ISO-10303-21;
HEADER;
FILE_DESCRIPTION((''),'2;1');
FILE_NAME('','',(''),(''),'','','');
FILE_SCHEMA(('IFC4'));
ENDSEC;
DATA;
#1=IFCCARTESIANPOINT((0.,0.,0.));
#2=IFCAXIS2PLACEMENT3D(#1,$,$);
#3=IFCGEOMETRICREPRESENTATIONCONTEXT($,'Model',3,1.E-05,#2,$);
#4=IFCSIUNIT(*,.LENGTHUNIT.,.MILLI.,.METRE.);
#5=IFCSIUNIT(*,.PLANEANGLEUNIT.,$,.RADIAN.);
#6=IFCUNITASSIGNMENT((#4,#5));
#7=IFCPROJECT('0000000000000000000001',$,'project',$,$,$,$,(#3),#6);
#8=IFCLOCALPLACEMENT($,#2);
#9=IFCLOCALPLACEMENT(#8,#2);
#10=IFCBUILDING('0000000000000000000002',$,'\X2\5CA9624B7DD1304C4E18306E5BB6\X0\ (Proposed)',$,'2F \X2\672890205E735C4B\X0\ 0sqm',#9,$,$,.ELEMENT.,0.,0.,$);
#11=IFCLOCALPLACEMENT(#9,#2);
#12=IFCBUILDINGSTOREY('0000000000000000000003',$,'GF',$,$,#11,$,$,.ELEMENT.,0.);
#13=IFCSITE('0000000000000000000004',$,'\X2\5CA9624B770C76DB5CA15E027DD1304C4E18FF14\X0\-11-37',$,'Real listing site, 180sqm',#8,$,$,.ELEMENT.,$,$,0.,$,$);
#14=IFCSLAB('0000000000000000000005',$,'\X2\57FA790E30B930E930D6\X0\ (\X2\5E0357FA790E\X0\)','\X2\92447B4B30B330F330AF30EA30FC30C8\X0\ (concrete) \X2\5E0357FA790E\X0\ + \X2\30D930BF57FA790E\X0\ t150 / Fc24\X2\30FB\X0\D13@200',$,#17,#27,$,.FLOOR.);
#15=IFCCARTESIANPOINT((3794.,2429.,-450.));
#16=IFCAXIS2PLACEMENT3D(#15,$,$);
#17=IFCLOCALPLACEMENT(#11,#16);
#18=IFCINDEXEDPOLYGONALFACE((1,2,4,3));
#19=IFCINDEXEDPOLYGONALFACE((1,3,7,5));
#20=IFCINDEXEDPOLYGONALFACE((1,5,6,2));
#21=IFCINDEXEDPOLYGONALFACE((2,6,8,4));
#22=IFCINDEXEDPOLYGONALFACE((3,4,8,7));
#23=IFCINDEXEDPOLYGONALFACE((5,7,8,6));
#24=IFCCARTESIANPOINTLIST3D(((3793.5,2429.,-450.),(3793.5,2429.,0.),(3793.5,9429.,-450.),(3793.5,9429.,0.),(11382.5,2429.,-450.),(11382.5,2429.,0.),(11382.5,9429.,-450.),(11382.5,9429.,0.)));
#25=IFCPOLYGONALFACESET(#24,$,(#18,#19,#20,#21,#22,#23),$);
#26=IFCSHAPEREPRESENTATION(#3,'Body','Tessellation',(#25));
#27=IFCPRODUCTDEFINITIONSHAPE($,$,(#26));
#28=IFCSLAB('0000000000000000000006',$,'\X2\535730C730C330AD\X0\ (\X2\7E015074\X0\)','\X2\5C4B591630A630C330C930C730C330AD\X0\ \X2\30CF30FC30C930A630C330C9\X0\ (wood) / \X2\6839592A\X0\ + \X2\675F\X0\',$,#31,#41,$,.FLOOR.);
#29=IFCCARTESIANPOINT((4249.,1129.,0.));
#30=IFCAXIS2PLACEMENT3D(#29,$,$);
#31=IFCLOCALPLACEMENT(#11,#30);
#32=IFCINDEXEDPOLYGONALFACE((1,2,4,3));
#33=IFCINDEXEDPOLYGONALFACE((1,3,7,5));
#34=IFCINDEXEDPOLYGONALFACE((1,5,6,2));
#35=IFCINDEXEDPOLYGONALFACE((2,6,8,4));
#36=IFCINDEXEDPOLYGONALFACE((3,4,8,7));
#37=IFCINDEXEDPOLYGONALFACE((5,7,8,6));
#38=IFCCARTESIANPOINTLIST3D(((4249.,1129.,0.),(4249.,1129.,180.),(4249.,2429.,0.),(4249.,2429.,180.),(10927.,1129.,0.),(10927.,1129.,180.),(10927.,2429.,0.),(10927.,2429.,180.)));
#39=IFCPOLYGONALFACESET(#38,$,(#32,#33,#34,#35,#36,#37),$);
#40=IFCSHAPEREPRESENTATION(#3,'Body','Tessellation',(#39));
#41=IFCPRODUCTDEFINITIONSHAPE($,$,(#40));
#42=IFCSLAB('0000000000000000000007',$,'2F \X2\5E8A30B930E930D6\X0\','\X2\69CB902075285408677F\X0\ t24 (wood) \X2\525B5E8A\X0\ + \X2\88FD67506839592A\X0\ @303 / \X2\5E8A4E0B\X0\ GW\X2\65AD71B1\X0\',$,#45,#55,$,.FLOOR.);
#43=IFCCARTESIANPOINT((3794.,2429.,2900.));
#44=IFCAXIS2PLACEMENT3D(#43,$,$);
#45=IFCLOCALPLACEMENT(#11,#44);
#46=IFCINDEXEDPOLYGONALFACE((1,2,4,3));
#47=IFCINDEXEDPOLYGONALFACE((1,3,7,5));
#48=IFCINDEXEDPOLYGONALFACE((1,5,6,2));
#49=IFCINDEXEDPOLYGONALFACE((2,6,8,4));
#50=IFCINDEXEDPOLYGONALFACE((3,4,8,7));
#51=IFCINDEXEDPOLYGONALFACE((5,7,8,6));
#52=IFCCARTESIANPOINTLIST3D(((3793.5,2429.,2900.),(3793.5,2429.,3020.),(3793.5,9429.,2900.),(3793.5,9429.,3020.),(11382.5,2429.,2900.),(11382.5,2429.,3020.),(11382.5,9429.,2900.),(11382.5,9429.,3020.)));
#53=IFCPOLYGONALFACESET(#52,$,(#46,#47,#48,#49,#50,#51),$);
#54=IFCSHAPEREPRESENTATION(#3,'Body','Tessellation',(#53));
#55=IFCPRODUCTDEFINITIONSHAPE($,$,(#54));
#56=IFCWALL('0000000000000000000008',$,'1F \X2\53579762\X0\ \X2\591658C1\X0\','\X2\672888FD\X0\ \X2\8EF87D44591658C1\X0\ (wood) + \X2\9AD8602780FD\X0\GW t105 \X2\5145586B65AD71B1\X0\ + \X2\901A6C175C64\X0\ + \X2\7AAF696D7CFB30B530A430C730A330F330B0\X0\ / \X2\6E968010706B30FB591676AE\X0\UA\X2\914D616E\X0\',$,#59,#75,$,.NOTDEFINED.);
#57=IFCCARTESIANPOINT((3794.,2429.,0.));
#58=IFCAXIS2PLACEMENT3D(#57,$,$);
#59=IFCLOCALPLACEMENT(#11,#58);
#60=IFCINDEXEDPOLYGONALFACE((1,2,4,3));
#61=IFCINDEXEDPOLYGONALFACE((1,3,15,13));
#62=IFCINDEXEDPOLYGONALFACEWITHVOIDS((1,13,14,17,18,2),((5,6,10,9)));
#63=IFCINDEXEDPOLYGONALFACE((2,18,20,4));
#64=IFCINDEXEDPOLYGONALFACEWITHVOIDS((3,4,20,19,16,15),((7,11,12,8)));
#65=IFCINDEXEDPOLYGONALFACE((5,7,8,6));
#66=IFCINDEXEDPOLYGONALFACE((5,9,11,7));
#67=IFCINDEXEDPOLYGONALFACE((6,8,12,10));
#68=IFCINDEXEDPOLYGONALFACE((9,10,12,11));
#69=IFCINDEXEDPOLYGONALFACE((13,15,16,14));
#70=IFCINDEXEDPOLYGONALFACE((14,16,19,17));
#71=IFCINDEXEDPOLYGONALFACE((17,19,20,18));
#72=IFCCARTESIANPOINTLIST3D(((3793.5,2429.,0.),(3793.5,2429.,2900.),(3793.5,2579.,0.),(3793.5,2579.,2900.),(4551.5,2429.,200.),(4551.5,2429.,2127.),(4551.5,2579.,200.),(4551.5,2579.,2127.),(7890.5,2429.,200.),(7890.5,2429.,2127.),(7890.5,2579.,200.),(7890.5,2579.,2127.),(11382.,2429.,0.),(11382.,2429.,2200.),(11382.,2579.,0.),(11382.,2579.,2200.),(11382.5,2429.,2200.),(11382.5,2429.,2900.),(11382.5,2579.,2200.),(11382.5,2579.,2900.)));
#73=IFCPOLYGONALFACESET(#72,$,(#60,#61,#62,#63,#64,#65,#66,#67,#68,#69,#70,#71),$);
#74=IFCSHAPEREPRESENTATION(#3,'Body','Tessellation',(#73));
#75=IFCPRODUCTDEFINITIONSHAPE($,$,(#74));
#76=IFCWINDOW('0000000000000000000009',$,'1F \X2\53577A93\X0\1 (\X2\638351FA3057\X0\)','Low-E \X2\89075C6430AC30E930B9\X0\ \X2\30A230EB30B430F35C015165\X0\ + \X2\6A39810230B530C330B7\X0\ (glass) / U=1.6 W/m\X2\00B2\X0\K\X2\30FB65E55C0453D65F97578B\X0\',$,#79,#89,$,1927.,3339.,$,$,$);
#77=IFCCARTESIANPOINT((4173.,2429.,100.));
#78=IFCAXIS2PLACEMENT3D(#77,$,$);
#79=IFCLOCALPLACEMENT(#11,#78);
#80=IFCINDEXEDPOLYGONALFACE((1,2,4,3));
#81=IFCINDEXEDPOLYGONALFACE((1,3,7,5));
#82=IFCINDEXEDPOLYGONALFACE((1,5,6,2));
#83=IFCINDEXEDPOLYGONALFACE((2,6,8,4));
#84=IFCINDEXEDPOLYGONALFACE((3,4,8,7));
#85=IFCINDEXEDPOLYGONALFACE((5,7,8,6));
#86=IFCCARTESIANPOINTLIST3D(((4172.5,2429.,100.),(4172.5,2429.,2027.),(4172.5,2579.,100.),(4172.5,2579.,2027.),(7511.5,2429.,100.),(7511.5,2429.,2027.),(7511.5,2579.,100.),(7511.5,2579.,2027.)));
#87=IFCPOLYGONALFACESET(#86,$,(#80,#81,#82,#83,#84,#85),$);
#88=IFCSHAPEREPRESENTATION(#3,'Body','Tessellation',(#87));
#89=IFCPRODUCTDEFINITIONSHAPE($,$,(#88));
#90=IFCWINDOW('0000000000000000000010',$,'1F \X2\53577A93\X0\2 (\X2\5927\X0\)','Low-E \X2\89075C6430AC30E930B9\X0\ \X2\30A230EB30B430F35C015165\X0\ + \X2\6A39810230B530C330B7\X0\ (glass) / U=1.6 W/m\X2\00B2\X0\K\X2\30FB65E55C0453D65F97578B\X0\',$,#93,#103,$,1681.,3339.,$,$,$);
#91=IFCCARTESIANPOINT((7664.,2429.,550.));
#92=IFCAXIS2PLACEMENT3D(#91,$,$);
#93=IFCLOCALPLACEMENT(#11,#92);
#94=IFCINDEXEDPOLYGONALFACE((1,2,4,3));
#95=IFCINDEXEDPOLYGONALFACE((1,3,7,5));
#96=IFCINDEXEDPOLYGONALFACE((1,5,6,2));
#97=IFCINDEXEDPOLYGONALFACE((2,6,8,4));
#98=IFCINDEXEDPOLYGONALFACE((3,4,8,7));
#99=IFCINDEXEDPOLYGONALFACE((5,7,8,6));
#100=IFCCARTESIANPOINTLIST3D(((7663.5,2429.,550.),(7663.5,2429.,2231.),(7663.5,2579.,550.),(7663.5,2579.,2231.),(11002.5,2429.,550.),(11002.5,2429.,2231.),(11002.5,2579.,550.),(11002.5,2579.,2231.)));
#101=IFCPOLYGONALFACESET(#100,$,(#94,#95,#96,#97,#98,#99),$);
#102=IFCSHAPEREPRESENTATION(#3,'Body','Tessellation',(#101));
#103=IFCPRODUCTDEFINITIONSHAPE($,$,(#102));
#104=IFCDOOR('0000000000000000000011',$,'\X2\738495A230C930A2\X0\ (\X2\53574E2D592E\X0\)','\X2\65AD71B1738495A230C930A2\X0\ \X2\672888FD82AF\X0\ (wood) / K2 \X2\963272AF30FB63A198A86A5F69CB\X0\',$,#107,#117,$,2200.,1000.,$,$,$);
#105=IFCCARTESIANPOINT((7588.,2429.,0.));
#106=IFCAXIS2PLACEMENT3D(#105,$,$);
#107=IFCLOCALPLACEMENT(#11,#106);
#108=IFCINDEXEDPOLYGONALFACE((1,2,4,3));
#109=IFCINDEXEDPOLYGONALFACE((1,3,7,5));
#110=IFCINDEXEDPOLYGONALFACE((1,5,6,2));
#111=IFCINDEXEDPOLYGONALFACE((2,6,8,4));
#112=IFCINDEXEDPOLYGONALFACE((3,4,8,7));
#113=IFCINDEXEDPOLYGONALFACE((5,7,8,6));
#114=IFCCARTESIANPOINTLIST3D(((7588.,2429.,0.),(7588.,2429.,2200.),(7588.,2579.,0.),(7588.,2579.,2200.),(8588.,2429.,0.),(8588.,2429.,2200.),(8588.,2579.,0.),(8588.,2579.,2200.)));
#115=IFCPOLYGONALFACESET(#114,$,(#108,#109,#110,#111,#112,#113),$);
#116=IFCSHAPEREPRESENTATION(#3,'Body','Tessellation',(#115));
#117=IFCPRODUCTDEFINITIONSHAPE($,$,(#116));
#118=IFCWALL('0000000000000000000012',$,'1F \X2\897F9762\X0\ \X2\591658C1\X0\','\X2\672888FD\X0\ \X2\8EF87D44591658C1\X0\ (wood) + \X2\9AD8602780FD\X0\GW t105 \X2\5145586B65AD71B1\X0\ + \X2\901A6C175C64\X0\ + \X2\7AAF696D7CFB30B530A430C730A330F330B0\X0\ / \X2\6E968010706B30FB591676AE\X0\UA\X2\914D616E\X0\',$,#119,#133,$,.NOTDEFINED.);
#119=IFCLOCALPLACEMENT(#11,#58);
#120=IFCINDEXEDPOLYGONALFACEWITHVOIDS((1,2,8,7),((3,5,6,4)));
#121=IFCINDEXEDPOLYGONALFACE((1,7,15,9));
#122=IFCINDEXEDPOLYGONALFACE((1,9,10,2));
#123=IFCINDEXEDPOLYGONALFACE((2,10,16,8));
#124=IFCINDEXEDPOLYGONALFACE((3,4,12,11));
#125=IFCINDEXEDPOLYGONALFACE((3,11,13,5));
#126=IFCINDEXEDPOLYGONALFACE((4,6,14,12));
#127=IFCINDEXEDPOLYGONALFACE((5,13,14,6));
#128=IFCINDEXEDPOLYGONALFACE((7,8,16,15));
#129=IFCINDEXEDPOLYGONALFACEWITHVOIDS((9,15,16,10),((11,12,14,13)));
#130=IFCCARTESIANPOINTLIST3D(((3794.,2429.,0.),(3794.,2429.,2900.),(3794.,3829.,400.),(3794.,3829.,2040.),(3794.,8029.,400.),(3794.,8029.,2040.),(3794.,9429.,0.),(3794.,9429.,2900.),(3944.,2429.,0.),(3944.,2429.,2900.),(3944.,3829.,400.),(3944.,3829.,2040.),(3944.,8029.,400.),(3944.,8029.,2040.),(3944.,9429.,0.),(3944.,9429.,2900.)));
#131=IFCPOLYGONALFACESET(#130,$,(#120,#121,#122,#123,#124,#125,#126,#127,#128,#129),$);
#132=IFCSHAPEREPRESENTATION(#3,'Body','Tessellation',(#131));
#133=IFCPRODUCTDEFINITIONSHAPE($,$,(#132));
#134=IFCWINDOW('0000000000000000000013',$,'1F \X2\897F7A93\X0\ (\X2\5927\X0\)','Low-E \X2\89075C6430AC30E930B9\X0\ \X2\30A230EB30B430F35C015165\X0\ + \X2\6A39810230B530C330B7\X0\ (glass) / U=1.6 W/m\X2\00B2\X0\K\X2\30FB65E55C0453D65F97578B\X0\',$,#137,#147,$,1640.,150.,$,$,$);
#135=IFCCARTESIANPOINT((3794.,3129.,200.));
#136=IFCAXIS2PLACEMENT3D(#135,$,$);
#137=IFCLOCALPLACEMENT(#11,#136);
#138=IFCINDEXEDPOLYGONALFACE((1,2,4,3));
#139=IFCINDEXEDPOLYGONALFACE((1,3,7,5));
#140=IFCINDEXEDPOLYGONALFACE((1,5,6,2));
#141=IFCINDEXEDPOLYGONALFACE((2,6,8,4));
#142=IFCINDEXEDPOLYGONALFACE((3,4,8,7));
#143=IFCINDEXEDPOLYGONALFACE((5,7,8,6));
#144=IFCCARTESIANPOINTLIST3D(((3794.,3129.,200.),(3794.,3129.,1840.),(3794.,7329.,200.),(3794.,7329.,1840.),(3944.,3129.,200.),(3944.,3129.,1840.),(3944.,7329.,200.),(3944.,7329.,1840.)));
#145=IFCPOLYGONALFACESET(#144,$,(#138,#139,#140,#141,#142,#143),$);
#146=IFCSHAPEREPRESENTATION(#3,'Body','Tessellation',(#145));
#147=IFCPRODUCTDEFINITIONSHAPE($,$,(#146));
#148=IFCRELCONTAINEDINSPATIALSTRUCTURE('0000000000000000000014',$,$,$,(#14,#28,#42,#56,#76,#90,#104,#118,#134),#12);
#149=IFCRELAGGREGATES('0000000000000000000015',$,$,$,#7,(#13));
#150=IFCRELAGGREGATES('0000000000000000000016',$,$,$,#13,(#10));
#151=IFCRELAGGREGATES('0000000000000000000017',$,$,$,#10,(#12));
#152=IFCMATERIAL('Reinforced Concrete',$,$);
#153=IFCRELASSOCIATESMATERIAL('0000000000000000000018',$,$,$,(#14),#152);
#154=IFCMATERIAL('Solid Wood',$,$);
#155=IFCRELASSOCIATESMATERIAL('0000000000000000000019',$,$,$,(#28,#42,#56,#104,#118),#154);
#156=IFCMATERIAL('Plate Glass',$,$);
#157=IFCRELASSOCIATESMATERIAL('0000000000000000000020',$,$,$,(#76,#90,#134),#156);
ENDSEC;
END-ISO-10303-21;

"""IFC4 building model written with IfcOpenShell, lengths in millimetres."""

from ifc_helpers import new_model, si_unit, frame, frame_2d, origin, place, context, project, spatial, rectangle, extrude, material, element, fill, save


model = new_model("IFC4")

# Units and contexts
model_context = context("Model", 3, precision=1e-05, world=origin())
ifc_project = project(units=[si_unit("LENGTHUNIT", "METRE", prefix="MILLI"), si_unit("PLANEANGLEUNIT", "RADIAN")], contexts=[model_context])

# Site, building, storey
site_placement = place(None, origin())
site = spatial("IfcSite", under=ifc_project, at=site_placement, Name="岩手県盛岡市緑が丘４-11-37", ObjectType="Real listing site, 180sqm", CompositionType="ELEMENT", RefElevation=0.0)
building_placement = place(site_placement, origin())
building = spatial("IfcBuilding", under=site, at=building_placement, Name="岩手緑が丘の家 (Proposed)", ObjectType="2F 木造平屋 0sqm", CompositionType="ELEMENT", ElevationOfRefHeight=0.0, ElevationOfTerrain=0.0)
storey_placement = place(building_placement, origin())
storey = spatial("IfcBuildingStorey", under=building, at=storey_placement, Name="GF", CompositionType="ELEMENT", Elevation=0.0)

# Slabs
ifc_material_1 = material(Name="Reinforced Concrete")
slab_1_placement = place(storey_placement, frame((3794.0, 2429.0, -450.0)))
element("IfcSlab", 1, at=slab_1_placement, inside=storey, material=ifc_material_1, Name="基礎スラブ (布基礎)", Description="鉄筋コンクリート (concrete) 布基礎 + ベタ基礎 t150 / Fc24・D13@200", PredefinedType="FLOOR", context=model_context, shape_type="SweptSolid", body=[
    extrude(rectangle(XDim=7589.0, YDim=7000.0, at=frame_2d((3794.0, 3500.0))), frame((3794.0, 2429.0, -450.0)), (0.0, 0.0, 1.0), 450.0),
])
ifc_material_2 = material(Name="Solid Wood")
slab_2_placement = place(storey_placement, frame((4249.0, 1129.0, 0.0)))
element("IfcSlab", 2, at=slab_2_placement, inside=storey, material=ifc_material_2, Name="南デッキ (縁側)", Description="屋外ウッドデッキ ハードウッド (wood) / 根太 + 束", PredefinedType="FLOOR", context=model_context, shape_type="SweptSolid", body=[
    extrude(rectangle(XDim=6678.0, YDim=1300.0, at=frame_2d((3339.0, 650.0))), frame((4249.0, 1129.0, 0.0)), (0.0, 0.0, 1.0), 180.0),
])
slab_3_placement = place(storey_placement, frame((3794.0, 2429.0, 2900.0)))
element("IfcSlab", 3, at=slab_3_placement, inside=storey, material=ifc_material_2, Name="2F 床スラブ", Description="構造用合板 t24 (wood) 剛床 + 製材根太 @303 / 床下 GW断熱", PredefinedType="FLOOR", context=model_context, shape_type="SweptSolid", body=[
    extrude(rectangle(XDim=7589.0, YDim=7000.0, at=frame_2d((3794.0, 3500.0))), frame((3794.0, 2429.0, 2900.0)), (0.0, 0.0, 1.0), 120.0),
])

# Wall, openings, windows, door
wall_1_placement = place(storey_placement, frame((3794.0, 2429.0, 0.0)))
wall_1 = element("IfcWall", 4, at=wall_1_placement, inside=storey, material=ifc_material_2, Name="1F 南面 外壁", Description="木製 軸組外壁 (wood) + 高性能GW t105 充填断熱 + 通気層 + 窯業系サイディング / 準耐火・外皮UA配慮", PredefinedType="NOTDEFINED", context=model_context, shape_type="SweptSolid", body=[
    extrude(rectangle(XDim=7589.0, YDim=150.0, at=frame_2d((3794.0, 75.0))), frame((3794.0, 2429.0, 0.0)), (0.0, 0.0, 1.0), 2900.0),
])
opening_1_placement = place(storey_placement, frame((4173.0, 2429.0, 100.0)))
opening_1 = element("IfcOpeningElement", 5, at=opening_1_placement, cuts=wall_1, PredefinedType="NOTDEFINED", context=model_context, shape_type="SweptSolid", body=[
    extrude(rectangle(XDim=3339.0, YDim=150.0, at=frame_2d((1669.0, 75.0))), frame((4173.0, 2429.0, 100.0)), (0.0, 0.0, 1.0), 1927.0),
])
opening_2_placement = place(storey_placement, frame((7664.0, 2429.0, 550.0)))
opening_2 = element("IfcOpeningElement", 6, at=opening_2_placement, cuts=wall_1, PredefinedType="NOTDEFINED", context=model_context, shape_type="SweptSolid", body=[
    extrude(rectangle(XDim=3339.0, YDim=150.0, at=frame_2d((1669.0, 75.0))), frame((7664.0, 2429.0, 550.0)), (0.0, 0.0, 1.0), 1681.0),
])
opening_3_placement = place(storey_placement, frame((7588.0, 2429.0, 0.0)))
opening_3 = element("IfcOpeningElement", 7, at=opening_3_placement, cuts=wall_1, PredefinedType="NOTDEFINED", context=model_context, shape_type="SweptSolid", body=[
    extrude(rectangle(XDim=1000.0, YDim=150.0, at=frame_2d((500.0, 75.0))), frame((7588.0, 2429.0, 0.0)), (0.0, 0.0, 1.0), 2200.0),
])
ifc_material_3 = material(Name="Plate Glass")
window_1_placement = place(storey_placement, frame((4173.0, 2429.0, 100.0)))
window_1 = element("IfcWindow", 8, at=window_1_placement, inside=storey, material=ifc_material_3, Name="1F 南窓1 (掃出し)", Description="Low-E 複層ガラス アルゴン封入 + 樹脂サッシ (glass) / U=1.6 W/m²K・日射取得型", OverallHeight=1927.0, OverallWidth=3339.0, context=model_context, shape_type="SweptSolid", body=[
    extrude(rectangle(XDim=3339.0, YDim=150.0, at=frame_2d((1669.0, 75.0))), frame((4173.0, 2429.0, 100.0)), (0.0, 0.0, 1.0), 1927.0),
])
fill(opening_1, window_1)
window_2_placement = place(storey_placement, frame((7664.0, 2429.0, 550.0)))
window_2 = element("IfcWindow", 9, at=window_2_placement, inside=storey, material=ifc_material_3, Name="1F 南窓2 (大)", Description="Low-E 複層ガラス アルゴン封入 + 樹脂サッシ (glass) / U=1.6 W/m²K・日射取得型", OverallHeight=1681.0, OverallWidth=3339.0, context=model_context, shape_type="SweptSolid", body=[
    extrude(rectangle(XDim=3339.0, YDim=150.0, at=frame_2d((1669.0, 75.0))), frame((7664.0, 2429.0, 550.0)), (0.0, 0.0, 1.0), 1681.0),
])
fill(opening_2, window_2)
door_placement = place(storey_placement, frame((7588.0, 2429.0, 0.0)))
door = element("IfcDoor", 10, at=door_placement, inside=storey, material=ifc_material_2, Name="玄関ドア (南中央)", Description="断熱玄関ドア 木製芯 (wood) / K2 防犯・採風機構", OverallHeight=2200.0, OverallWidth=1000.0, context=model_context, shape_type="SweptSolid", body=[
    extrude(rectangle(XDim=1000.0, YDim=150.0, at=frame_2d((500.0, 75.0))), frame((7588.0, 2429.0, 0.0)), (0.0, 0.0, 1.0), 2200.0),
])
fill(opening_3, door)

# Wall, opening, window
wall_2_placement = place(storey_placement, frame((3794.0, 2429.0, 0.0)))
wall_2 = element("IfcWall", 11, at=wall_2_placement, inside=storey, material=ifc_material_2, Name="1F 西面 外壁", Description="木製 軸組外壁 (wood) + 高性能GW t105 充填断熱 + 通気層 + 窯業系サイディング / 準耐火・外皮UA配慮", PredefinedType="NOTDEFINED", context=model_context, shape_type="SweptSolid", body=[
    extrude(rectangle(XDim=150.0, YDim=7000.0, at=frame_2d((75.0, 3500.0))), frame((3794.0, 2429.0, 0.0)), (0.0, 0.0, 1.0), 2900.0),
])
opening_4_placement = place(storey_placement, frame((3794.0, 3129.0, 200.0)))
opening_4 = element("IfcOpeningElement", 12, at=opening_4_placement, cuts=wall_2, PredefinedType="NOTDEFINED", context=model_context, shape_type="SweptSolid", body=[
    extrude(rectangle(XDim=150.0, YDim=4200.0, at=frame_2d((75.0, 2100.0))), frame((3794.0, 3129.0, 200.0)), (0.0, 0.0, 1.0), 1640.0),
])
window_3_placement = place(storey_placement, frame((3794.0, 3129.0, 200.0)))
window_3 = element("IfcWindow", 13, at=window_3_placement, inside=storey, material=ifc_material_3, Name="1F 西窓 (大)", Description="Low-E 複層ガラス アルゴン封入 + 樹脂サッシ (glass) / U=1.6 W/m²K・日射取得型", OverallHeight=1640.0, OverallWidth=150.0, context=model_context, shape_type="SweptSolid", body=[
    extrude(rectangle(XDim=150.0, YDim=4200.0, at=frame_2d((75.0, 2100.0))), frame((3794.0, 3129.0, 200.0)), (0.0, 0.0, 1.0), 1640.0),
])
fill(opening_4, window_3)

save(model, "model.ifc")
